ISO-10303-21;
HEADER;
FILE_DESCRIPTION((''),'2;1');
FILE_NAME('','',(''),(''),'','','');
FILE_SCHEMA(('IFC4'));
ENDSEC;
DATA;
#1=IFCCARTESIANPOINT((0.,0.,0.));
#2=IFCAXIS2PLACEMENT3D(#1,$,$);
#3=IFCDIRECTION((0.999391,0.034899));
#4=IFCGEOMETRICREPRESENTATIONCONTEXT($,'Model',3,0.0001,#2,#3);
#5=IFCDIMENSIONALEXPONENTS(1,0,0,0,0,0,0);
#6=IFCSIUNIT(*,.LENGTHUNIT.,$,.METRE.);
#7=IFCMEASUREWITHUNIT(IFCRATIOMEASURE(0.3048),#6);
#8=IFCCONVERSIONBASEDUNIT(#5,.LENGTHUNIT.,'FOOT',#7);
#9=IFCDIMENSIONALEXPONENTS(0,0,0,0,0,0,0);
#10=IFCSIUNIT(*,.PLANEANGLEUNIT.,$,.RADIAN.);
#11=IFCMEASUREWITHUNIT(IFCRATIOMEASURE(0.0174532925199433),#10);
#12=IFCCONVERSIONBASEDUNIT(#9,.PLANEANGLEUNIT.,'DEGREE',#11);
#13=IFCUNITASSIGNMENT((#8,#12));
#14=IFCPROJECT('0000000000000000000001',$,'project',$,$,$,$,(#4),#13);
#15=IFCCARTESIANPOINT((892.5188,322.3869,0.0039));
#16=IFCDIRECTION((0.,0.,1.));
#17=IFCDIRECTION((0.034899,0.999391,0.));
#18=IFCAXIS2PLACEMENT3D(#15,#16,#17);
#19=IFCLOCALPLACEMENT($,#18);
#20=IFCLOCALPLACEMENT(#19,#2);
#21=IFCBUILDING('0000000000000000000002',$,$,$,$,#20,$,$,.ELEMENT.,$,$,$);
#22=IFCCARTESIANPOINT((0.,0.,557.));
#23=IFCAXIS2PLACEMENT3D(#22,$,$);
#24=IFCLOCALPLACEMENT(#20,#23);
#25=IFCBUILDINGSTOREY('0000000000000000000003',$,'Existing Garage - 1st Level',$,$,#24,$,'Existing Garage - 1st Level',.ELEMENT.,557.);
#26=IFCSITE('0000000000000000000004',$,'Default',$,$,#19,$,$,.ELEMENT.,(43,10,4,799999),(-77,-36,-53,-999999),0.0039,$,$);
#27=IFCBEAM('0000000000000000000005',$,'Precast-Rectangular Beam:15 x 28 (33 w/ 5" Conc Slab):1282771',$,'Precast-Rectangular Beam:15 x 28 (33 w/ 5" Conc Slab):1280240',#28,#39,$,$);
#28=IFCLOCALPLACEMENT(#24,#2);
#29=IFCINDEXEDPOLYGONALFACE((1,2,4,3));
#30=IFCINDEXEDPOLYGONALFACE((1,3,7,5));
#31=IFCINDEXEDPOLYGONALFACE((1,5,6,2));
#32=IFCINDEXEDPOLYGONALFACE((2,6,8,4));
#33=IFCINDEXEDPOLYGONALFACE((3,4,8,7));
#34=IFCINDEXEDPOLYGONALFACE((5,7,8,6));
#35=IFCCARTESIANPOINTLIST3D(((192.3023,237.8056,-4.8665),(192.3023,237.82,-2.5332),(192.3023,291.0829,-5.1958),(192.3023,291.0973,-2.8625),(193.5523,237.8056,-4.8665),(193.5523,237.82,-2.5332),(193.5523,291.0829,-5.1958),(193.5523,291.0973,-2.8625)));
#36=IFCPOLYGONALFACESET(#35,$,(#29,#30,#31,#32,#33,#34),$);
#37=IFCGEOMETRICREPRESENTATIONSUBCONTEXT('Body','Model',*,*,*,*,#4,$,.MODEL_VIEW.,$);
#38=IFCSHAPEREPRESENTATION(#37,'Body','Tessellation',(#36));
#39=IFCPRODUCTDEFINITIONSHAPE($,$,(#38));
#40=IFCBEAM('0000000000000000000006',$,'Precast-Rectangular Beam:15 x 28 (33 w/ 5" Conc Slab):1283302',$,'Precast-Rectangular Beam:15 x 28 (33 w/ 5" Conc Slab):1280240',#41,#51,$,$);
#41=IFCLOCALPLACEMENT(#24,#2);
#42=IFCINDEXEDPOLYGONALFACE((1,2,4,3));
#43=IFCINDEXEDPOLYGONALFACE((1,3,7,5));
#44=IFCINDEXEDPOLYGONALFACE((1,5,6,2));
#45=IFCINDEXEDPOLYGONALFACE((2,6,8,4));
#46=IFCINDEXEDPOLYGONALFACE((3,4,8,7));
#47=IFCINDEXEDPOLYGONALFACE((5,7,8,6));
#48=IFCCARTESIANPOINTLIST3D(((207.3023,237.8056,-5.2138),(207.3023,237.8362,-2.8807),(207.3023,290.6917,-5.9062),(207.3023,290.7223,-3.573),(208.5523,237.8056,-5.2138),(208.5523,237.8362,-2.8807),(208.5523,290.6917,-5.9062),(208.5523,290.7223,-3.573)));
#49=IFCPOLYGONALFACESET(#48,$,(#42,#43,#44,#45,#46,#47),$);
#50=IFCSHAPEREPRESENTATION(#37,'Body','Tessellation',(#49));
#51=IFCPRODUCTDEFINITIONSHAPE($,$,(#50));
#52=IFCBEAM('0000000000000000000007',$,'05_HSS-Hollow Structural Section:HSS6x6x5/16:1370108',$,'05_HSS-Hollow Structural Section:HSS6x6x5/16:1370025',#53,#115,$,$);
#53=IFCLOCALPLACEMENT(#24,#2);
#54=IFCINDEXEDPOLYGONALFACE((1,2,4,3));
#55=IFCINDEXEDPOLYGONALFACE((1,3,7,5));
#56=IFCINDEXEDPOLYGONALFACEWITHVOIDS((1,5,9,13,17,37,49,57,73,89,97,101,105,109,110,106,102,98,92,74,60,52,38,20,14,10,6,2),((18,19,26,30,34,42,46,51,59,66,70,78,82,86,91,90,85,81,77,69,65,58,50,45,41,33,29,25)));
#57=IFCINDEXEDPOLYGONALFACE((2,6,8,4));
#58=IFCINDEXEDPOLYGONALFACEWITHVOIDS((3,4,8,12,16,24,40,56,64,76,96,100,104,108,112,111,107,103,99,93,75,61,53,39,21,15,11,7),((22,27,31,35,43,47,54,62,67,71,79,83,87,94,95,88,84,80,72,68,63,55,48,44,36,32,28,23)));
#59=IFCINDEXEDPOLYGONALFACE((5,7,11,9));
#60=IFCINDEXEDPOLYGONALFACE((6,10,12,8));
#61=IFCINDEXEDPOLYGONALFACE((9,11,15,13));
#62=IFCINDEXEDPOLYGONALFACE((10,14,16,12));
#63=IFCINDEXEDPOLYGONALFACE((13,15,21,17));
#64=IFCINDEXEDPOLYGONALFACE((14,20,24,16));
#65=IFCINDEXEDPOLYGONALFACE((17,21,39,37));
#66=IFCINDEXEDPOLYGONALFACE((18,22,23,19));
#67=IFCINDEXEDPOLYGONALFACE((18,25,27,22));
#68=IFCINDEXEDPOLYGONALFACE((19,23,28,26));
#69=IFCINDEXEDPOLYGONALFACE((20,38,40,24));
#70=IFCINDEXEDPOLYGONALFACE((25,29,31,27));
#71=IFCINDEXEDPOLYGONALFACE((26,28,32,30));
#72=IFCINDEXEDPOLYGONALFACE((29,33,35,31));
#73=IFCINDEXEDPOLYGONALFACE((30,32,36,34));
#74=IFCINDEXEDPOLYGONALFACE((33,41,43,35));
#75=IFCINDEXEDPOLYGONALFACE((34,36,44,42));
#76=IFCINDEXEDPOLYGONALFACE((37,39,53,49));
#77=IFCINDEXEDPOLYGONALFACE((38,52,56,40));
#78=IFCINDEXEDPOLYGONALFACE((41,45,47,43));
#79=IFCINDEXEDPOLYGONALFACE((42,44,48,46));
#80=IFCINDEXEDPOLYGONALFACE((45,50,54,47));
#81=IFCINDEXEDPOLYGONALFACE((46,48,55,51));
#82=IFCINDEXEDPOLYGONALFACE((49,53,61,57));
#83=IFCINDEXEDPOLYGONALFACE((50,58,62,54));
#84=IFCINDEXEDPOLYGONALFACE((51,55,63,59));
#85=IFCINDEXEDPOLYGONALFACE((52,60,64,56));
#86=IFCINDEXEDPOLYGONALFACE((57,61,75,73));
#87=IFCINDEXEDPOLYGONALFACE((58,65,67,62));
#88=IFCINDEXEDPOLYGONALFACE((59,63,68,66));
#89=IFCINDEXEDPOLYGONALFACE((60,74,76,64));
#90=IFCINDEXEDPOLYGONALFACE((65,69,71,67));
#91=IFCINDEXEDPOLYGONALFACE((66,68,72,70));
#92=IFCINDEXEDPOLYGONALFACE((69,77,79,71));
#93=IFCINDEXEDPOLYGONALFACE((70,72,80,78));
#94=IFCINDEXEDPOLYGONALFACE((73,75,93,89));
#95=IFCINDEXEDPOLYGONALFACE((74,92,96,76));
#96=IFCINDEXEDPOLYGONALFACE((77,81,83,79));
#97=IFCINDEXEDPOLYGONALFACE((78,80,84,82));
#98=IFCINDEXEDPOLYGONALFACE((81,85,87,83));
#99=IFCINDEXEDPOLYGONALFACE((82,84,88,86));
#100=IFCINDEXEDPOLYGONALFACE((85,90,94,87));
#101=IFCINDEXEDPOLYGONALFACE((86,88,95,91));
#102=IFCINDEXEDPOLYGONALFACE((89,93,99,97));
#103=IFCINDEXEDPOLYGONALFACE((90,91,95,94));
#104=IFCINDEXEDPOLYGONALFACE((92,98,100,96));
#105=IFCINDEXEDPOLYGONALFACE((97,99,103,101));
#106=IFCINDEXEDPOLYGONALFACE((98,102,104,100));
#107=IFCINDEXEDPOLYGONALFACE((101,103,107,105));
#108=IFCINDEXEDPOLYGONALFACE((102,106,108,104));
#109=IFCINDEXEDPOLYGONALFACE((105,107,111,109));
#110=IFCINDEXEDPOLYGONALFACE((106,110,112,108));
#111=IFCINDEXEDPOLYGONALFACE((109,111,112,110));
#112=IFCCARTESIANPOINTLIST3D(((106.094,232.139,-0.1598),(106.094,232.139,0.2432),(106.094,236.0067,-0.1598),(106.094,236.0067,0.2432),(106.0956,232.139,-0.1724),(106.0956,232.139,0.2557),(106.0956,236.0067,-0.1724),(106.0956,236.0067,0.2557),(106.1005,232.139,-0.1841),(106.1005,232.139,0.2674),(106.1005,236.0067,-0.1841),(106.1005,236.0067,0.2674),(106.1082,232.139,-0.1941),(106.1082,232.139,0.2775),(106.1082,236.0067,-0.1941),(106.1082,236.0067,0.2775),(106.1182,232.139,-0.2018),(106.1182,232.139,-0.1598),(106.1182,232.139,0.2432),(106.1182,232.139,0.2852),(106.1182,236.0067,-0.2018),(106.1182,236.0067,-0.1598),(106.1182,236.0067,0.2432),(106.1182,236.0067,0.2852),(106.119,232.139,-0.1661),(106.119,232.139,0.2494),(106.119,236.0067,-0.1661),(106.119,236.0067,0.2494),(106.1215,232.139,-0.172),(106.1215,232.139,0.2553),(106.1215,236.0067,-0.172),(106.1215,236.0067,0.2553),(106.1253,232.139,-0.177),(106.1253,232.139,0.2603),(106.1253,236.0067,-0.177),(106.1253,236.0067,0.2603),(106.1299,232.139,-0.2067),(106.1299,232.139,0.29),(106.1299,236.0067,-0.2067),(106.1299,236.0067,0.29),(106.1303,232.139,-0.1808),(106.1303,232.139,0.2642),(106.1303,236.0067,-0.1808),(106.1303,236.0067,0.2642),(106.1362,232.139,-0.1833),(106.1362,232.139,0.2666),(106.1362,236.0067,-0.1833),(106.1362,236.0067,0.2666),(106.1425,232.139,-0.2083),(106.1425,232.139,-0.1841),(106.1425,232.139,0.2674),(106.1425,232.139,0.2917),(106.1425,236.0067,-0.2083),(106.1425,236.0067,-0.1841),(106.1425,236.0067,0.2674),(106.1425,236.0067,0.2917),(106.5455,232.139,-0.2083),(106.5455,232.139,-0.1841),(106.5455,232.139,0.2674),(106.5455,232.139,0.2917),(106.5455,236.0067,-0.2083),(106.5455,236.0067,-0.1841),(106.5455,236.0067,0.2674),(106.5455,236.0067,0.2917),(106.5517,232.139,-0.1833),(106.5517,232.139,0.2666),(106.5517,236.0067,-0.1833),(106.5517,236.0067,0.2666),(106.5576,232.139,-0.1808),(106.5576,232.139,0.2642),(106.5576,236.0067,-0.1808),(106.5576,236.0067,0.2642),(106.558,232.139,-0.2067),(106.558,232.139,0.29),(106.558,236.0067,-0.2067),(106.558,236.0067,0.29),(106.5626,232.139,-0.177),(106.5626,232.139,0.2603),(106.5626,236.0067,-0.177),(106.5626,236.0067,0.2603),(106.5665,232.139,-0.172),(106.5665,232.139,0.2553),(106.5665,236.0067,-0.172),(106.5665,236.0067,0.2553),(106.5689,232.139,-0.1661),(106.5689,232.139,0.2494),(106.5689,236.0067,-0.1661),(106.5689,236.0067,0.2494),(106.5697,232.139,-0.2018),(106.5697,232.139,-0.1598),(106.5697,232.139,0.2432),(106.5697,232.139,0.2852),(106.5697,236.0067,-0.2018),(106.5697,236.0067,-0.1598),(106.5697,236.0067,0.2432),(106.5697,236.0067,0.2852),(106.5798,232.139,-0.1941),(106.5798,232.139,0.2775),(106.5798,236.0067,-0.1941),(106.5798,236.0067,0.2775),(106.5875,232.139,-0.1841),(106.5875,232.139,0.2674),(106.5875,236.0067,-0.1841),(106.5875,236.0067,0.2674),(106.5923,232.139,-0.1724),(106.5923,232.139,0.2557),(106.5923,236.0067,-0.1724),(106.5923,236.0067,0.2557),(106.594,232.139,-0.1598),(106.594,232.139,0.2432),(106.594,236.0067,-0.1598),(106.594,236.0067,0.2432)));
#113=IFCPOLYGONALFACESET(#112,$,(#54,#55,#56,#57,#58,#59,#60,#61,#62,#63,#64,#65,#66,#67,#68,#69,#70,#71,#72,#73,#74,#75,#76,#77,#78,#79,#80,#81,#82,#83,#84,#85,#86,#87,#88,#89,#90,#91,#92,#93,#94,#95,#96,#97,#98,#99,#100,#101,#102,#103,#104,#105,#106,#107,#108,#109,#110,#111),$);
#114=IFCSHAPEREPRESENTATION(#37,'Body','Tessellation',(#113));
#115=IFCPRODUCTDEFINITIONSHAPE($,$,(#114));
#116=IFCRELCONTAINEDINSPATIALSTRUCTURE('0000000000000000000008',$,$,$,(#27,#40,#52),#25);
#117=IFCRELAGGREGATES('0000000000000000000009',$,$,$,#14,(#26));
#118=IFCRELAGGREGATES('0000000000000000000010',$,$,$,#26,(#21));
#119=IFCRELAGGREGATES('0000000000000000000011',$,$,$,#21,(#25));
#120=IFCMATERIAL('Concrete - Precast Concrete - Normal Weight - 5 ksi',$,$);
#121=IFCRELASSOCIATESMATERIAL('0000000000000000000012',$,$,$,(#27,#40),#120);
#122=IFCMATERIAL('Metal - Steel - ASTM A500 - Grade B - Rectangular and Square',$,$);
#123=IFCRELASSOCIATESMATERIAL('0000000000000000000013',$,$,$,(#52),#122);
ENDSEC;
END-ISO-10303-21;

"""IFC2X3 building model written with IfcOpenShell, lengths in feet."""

from ifc_helpers import new_model, entity, si_unit, converted_unit, direction, frame, frame_2d, origin, origin_2d_with_axis, place, context, subcontext, project, spatial, polyline, circle_curve, parameter, trimmed, segment, composite_curve, rectangle, outline, extrude, material, element, save


model = new_model("IFC2X3")

# Units and contexts
model_context = context("Model", 3, precision=0.0001, world=origin(), true_north=direction((0.999391, 0.034899)))
body_context = subcontext(model_context, "Body", "Model", "MODEL_VIEW")
ifc_project = project(units=[converted_unit("LENGTHUNIT", "FOOT", entity("IfcRatioMeasure", 0.3048), si_unit("LENGTHUNIT", "METRE"), dimensions=[1, 0, 0, 0, 0, 0, 0]), converted_unit("PLANEANGLEUNIT", "DEGREE", entity("IfcRatioMeasure", 0.0174532925199433), si_unit("PLANEANGLEUNIT", "RADIAN"), dimensions=[0, 0, 0, 0, 0, 0, 0])], contexts=[model_context])

# Site, building, storey
site_placement = place(None, frame((892.5188, 322.3869, 0.0039), z_axis=(0.0, 0.0, 1.0), x_axis=(0.034899, 0.999391, 0.0)))
site = spatial("IfcSite", under=ifc_project, at=site_placement, Name="Default", CompositionType="ELEMENT", RefLatitude=(43, 10, 4, 799999), RefLongitude=(-77, -36, -53, -999999), RefElevation=0.0039)
building_placement = place(site_placement, origin())
building = spatial("IfcBuilding", under=site, at=building_placement, CompositionType="ELEMENT")
storey_placement = place(building_placement, frame((0.0, 0.0, 557.0)))
storey = spatial("IfcBuildingStorey", under=building, at=storey_placement, Name="Existing Garage - 1st Level", LongName="Existing Garage - 1st Level", CompositionType="ELEMENT", Elevation=557.0)

# Beams
ifc_material_1 = material(Name="Concrete - Precast Concrete - Normal Weight - 5 ksi")
beam_1_placement = place(storey_placement, frame((192.9273, 236.764, -2.5267), z_axis=(0.0, 0.006182, 0.999981), x_axis=(0.0, 0.999981, -0.006182)))
element("IfcBeam", 1, at=beam_1_placement, inside=storey, material=ifc_material_1, Name="Precast-Rectangular Beam:15 x 28 (33 w/ 5\" Conc Slab):1282771", ObjectType="Precast-Rectangular Beam:15 x 28 (33 w/ 5\" Conc Slab):1280240", context=body_context, shape_type="SweptSolid", body=[
    extrude(rectangle(XDim=2.3333, YDim=1.25, at=frame_2d((0.0, 0.0), x_axis=(1.0, 0.0))), frame((1.0561, 0.0, -1.1667), z_axis=(1.0, 0.0, 0.0), x_axis=(0.0, 0.0, -1.0)), (0.0, 0.0, 1.0), 53.2783),
])
beam_2_placement = place(storey_placement, frame((207.9273, 236.764, -2.8667), z_axis=(0.0, 0.01309, 0.999914), x_axis=(0.0, 0.999914, -0.01309)))
element("IfcBeam", 2, at=beam_2_placement, inside=storey, material=ifc_material_1, Name="Precast-Rectangular Beam:15 x 28 (33 w/ 5\" Conc Slab):1283302", ObjectType="Precast-Rectangular Beam:15 x 28 (33 w/ 5\" Conc Slab):1280240", context=body_context, shape_type="SweptSolid", body=[
    extrude(rectangle(XDim=2.3333, YDim=1.25, at=origin_2d_with_axis()), frame((1.0723, 0.0, -1.1667), z_axis=(1.0, 0.0, 0.0), x_axis=(0.0, 0.0, -1.0)), (0.0, 0.0, 1.0), 52.8907),
])
ifc_material_2 = material(Name="Metal - Steel - ASTM A500 - Grade B - Rectangular and Square")
beam_3_placement = place(storey_placement, frame((106.344, 231.8473, 0.2917), z_axis=(0.0, 0.0, 1.0), x_axis=(0.0, 1.0, 0.0)))
element("IfcBeam", 3, at=beam_3_placement, inside=storey, material=ifc_material_2, Name="05_HSS-Hollow Structural Section:HSS6x6x5/16:1370108", ObjectType="05_HSS-Hollow Structural Section:HSS6x6x5/16:1370025", context=body_context, shape_type="SweptSolid", body=[
    extrude(outline(composite_curve([segment(trimmed(circle_curve(frame_2d((-0.2015, -0.2015), x_axis=(1.0, 0.0)), 0.0485), [parameter(180.0)], [parameter(270.0)], True, "PARAMETER"), True, "CONTINUOUS"), segment(polyline([(-0.2015, -0.25), (0.2015, -0.25)]), True, "CONTINUOUS"), segment(trimmed(circle_curve(frame_2d((0.2015, -0.2015), x_axis=(1.0, 0.0)), 0.0485), [parameter(270.0)], [parameter(0.0)], True, "PARAMETER"), True, "CONTINUOUS"), segment(polyline([(0.25, -0.2015), (0.25, 0.2015)]), True, "CONTINUOUS"), segment(trimmed(circle_curve(frame_2d((0.2015, 0.2015), x_axis=(1.0, 0.0)), 0.0485), [parameter(360.0)], [parameter(90.0)], True, "PARAMETER"), True, "CONTINUOUS"), segment(polyline([(0.2015, 0.25), (-0.2015, 0.25)]), True, "CONTINUOUS"), segment(trimmed(circle_curve(frame_2d((-0.2015, 0.2015), x_axis=(1.0, 0.0)), 0.0485), [parameter(90.0)], [parameter(180.0)], True, "PARAMETER"), True, "CONTINUOUS"), segment(polyline([(-0.25, 0.2015), (-0.25, -0.2015)]), True, "CONTINUOUS")], self_intersect=False), holes=[composite_curve([segment(polyline([(0.2015, -0.2257), (-0.2015, -0.2257)]), True, "CONTINUOUS"), segment(trimmed(circle_curve(frame_2d((-0.2015, -0.2015), x_axis=(1.0, 0.0)), 0.0243), [parameter(180.0)], [parameter(270.0)], True, "PARAMETER"), False, "CONTINUOUS"), segment(polyline([(-0.2258, -0.2015), (-0.2258, 0.2015)]), True, "CONTINUOUS"), segment(trimmed(circle_curve(frame_2d((-0.2015, 0.2015), x_axis=(1.0, 0.0)), 0.0243), [parameter(90.0)], [parameter(180.0)], True, "PARAMETER"), False, "CONTINUOUS"), segment(polyline([(-0.2015, 0.2258), (0.2015, 0.2258)]), True, "CONTINUOUS"), segment(trimmed(circle_curve(frame_2d((0.2015, 0.2015), x_axis=(1.0, 0.0)), 0.0243), [parameter(0.0)], [parameter(90.0)], True, "PARAMETER"), False, "CONTINUOUS"), segment(polyline([(0.2257, 0.2015), (0.2257, -0.2015)]), True, "CONTINUOUS"), segment(trimmed(circle_curve(frame_2d((0.2015, -0.2015), x_axis=(1.0, 0.0)), 0.0243), [parameter(270.0)], [parameter(0.0)], True, "PARAMETER"), False, "CONTINUOUS")], self_intersect=False)]), frame((0.2917, 0.0, -0.25), z_axis=(1.0, 0.0, 0.0), x_axis=(0.0, -1.0, 0.0)), (0.0, 0.0, 1.0), 3.8677),
])

save(model, "model.ifc")
